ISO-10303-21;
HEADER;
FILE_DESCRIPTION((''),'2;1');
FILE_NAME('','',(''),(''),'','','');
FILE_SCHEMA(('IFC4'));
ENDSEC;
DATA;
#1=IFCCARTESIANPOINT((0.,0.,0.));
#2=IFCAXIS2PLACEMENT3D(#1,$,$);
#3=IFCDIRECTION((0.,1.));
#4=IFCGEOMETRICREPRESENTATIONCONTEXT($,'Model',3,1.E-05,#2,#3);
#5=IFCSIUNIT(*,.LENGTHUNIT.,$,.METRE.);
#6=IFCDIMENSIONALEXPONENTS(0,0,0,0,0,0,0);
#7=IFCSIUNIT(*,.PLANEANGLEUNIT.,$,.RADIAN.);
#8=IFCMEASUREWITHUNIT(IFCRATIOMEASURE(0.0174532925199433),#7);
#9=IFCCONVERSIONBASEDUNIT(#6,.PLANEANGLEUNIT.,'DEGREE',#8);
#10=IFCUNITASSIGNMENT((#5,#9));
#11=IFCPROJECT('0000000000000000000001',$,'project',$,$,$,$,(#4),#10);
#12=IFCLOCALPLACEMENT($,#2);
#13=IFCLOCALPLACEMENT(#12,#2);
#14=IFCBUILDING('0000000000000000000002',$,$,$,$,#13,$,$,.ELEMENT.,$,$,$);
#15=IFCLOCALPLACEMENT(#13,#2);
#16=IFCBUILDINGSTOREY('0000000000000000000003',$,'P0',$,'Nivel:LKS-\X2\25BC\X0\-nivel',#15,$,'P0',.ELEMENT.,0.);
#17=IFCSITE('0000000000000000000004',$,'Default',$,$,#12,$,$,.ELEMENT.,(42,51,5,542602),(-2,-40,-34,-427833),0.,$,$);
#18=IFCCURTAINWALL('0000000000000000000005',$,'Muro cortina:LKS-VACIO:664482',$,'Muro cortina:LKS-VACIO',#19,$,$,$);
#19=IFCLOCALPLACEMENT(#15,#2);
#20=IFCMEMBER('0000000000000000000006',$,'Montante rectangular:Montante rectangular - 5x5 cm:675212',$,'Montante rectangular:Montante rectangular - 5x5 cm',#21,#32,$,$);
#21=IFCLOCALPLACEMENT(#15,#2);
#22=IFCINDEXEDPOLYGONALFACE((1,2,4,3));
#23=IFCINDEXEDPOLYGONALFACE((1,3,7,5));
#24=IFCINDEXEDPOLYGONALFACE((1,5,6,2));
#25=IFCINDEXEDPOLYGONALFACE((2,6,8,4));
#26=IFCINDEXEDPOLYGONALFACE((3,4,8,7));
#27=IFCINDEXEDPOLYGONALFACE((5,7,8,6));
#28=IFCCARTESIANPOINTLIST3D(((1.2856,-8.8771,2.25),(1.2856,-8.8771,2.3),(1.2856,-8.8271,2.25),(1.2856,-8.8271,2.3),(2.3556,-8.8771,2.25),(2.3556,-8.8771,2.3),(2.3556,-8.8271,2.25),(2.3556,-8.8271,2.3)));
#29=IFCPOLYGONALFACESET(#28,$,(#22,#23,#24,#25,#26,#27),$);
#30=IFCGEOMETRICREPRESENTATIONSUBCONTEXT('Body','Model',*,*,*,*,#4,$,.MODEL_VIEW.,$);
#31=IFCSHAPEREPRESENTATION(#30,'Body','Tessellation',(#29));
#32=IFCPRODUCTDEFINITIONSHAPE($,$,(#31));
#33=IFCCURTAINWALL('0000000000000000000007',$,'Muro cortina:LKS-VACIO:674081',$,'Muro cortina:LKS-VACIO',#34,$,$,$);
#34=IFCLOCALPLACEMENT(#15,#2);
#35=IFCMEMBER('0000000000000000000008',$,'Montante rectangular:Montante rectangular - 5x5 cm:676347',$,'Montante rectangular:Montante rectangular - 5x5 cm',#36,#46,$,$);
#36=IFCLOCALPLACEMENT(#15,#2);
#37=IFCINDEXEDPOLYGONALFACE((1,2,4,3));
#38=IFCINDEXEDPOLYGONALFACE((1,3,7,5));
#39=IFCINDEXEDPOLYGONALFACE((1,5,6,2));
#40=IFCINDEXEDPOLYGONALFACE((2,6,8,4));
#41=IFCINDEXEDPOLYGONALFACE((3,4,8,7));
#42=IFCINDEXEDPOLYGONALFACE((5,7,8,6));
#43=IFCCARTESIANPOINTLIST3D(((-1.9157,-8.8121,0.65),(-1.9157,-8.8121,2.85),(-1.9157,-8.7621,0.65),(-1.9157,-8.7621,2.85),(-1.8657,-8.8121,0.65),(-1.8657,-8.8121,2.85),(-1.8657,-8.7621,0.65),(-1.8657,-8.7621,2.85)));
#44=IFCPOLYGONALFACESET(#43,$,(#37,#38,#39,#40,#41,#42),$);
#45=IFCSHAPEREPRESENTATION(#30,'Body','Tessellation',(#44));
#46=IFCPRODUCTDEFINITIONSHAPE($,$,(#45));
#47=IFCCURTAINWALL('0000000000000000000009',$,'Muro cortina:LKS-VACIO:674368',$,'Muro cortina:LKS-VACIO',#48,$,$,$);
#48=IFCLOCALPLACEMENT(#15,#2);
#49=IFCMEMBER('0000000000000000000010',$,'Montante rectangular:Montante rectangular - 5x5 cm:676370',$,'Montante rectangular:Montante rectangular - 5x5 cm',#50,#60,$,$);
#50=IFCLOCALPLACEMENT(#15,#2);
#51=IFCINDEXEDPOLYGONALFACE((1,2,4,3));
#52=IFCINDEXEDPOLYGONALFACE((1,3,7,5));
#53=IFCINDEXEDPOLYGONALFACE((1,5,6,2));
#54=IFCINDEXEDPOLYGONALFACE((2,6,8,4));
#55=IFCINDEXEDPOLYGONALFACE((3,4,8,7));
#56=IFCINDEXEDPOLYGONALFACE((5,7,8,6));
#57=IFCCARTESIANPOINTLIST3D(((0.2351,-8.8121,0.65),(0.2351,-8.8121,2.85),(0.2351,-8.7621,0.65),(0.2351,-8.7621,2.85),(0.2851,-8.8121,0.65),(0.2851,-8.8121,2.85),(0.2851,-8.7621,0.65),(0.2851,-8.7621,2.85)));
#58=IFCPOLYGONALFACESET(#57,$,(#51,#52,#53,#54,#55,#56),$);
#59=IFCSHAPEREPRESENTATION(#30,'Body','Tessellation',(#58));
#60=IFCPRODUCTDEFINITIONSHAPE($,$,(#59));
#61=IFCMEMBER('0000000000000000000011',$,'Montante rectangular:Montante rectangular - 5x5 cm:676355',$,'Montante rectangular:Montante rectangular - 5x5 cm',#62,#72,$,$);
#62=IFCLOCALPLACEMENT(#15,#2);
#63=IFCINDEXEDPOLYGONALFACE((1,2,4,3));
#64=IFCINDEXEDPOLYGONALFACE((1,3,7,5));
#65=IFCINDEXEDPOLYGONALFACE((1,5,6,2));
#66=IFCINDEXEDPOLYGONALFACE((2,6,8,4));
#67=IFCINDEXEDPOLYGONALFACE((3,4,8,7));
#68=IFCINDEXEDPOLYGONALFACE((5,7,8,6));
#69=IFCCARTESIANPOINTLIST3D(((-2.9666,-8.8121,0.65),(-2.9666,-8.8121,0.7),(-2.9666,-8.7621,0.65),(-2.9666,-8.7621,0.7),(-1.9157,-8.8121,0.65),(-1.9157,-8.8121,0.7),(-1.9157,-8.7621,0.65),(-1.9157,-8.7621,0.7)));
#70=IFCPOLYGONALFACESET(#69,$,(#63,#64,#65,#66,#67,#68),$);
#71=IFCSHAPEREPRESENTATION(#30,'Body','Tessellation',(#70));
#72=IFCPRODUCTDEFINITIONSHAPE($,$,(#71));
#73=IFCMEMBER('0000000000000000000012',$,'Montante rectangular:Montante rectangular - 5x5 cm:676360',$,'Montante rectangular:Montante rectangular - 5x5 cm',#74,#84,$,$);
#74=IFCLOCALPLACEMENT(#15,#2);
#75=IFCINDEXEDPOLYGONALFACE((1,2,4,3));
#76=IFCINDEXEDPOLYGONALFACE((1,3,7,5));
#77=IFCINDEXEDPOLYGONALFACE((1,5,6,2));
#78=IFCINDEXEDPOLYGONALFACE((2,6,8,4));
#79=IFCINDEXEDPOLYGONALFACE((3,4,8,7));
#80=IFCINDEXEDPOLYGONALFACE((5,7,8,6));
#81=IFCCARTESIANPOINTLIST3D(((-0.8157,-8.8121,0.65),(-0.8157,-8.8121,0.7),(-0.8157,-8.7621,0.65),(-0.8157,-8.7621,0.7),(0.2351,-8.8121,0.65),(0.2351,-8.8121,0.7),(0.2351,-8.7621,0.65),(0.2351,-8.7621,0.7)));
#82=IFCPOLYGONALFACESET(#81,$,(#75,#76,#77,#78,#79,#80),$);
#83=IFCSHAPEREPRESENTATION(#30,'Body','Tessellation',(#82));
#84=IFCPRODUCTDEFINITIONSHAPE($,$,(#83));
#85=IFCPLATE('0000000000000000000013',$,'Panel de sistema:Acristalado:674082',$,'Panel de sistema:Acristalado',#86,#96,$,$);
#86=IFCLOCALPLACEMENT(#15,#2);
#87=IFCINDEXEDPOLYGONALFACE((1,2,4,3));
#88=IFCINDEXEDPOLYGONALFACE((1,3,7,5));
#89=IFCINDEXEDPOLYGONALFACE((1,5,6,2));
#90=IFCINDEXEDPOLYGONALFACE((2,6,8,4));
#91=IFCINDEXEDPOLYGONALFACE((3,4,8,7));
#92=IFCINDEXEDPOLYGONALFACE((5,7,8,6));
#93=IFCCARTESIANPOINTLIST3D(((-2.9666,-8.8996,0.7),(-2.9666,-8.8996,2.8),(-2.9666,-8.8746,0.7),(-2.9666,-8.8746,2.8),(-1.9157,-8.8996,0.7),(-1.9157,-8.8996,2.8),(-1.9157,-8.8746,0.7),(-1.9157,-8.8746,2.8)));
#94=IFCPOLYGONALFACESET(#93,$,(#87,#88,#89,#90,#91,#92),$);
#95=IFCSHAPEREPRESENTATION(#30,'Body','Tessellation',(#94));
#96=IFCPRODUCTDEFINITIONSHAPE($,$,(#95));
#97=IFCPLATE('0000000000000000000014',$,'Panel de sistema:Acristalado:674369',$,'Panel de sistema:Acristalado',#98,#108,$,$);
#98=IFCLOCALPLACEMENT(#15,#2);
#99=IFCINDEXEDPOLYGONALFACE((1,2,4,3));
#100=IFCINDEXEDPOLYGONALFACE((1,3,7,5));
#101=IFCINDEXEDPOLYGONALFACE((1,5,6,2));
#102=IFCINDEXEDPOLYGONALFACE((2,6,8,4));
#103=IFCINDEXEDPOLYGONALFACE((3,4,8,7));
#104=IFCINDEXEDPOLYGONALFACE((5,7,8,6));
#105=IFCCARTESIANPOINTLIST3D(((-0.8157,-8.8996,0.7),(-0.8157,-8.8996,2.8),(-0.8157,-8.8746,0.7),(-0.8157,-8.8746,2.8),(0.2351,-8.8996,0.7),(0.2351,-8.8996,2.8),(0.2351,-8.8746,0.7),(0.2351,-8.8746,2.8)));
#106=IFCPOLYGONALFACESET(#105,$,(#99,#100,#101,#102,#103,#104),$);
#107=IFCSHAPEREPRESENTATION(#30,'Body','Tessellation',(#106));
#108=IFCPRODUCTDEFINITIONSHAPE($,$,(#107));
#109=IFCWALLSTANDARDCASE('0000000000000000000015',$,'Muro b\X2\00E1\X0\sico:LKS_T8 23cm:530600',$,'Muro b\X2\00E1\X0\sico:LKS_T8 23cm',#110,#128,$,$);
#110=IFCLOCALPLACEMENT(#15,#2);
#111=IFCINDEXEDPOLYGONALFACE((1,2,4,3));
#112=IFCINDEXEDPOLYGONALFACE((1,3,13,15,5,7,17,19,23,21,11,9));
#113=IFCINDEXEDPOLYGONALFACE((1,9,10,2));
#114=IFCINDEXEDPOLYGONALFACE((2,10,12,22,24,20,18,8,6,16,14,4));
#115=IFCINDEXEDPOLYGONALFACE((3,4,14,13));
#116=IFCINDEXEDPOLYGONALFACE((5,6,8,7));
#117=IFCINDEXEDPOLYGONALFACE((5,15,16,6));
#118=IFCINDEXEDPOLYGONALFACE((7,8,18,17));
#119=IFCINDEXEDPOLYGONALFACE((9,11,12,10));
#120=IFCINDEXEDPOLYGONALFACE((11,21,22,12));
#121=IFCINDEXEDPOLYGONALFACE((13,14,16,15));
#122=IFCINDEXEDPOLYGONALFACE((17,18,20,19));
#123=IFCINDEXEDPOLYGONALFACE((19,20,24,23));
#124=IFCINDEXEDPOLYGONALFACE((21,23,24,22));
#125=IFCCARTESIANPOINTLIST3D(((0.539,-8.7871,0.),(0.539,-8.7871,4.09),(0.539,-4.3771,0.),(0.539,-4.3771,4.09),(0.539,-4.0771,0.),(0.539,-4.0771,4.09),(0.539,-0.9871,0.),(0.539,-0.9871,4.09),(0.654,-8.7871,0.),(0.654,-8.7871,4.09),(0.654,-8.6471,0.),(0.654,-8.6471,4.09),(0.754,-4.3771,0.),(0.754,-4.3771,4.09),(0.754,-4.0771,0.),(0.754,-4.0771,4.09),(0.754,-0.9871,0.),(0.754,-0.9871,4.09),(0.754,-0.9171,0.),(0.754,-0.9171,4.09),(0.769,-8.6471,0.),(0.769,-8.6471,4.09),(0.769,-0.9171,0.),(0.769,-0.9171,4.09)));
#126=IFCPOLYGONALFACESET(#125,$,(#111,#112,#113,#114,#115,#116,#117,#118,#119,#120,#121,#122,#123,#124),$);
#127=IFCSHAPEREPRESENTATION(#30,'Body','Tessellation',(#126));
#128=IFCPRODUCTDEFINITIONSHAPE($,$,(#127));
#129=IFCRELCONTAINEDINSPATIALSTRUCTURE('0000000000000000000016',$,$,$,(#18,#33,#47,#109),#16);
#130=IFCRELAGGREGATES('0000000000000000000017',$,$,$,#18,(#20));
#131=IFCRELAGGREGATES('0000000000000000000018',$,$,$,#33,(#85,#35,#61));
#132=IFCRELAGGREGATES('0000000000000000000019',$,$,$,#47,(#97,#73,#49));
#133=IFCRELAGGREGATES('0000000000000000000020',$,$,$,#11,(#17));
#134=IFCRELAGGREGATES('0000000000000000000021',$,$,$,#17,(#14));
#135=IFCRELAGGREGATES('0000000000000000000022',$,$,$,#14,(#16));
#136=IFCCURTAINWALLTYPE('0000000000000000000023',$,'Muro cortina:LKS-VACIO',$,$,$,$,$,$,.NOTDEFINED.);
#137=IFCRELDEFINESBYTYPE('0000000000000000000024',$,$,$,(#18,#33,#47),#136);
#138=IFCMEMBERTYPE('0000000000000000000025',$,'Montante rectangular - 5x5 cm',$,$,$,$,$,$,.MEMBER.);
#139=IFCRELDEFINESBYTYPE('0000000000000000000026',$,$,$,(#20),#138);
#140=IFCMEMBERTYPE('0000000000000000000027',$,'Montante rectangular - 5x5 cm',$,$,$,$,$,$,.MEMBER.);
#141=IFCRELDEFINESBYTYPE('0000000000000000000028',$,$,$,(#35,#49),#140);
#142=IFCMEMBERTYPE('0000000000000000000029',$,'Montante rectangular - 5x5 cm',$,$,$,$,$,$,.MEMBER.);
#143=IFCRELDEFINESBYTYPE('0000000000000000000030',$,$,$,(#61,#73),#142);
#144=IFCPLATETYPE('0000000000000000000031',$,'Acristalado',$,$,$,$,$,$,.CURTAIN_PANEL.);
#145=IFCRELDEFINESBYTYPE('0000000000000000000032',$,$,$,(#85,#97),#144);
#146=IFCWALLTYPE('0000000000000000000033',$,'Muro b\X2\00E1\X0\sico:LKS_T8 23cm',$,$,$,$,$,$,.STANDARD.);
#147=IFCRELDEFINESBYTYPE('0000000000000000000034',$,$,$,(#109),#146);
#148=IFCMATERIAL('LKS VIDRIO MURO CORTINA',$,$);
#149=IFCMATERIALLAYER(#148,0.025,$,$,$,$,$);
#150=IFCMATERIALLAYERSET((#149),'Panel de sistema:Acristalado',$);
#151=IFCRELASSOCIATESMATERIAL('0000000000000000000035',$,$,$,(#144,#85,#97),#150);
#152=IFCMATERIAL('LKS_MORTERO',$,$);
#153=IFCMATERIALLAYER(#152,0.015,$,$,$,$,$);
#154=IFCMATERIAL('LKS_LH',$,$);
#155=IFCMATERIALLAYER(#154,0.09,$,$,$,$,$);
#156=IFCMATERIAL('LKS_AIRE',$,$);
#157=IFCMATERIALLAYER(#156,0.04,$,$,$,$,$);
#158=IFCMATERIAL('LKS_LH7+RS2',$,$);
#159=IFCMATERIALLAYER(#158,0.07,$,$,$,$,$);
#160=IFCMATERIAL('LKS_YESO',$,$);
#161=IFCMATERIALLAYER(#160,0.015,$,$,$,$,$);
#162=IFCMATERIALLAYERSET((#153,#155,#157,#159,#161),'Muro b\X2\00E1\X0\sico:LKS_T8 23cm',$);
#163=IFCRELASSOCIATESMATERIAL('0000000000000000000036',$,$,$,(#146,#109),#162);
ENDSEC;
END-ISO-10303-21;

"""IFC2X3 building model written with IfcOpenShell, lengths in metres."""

from ifc_helpers import new_model, entity, si_unit, converted_unit, direction, frame, frame_2d, origin, origin_2d_with_axis, place, context, subcontext, project, spatial, polyline, rectangle, extrude, clip, bounded_halfspace, source, transform, mapped, material, layer, layer_set, layer_usage, type_object, type_shapes, element, aggregate, save


model = new_model("IFC2X3")

# Units and contexts
model_context = context("Model", 3, precision=1e-05, world=origin(), true_north=direction((0.0, 1.0)))
body_context = subcontext(model_context, "Body", "Model", "MODEL_VIEW")
ifc_project = project(units=[si_unit("LENGTHUNIT", "METRE"), converted_unit("PLANEANGLEUNIT", "DEGREE", entity("IfcRatioMeasure", 0.0174532925199433), si_unit("PLANEANGLEUNIT", "RADIAN"), dimensions=[0, 0, 0, 0, 0, 0, 0])], contexts=[model_context])

# Site, building, storey
site_placement = place(None, origin())
site = spatial("IfcSite", under=ifc_project, at=site_placement, Name="Default", CompositionType="ELEMENT", RefLatitude=(42, 51, 5, 542602), RefLongitude=(-2, -40, -34, -427833), RefElevation=0.0)
building_placement = place(site_placement, origin())
building = spatial("IfcBuilding", under=site, at=building_placement, CompositionType="ELEMENT")
storey_placement = place(building_placement, origin())
storey = spatial("IfcBuildingStorey", under=building, at=storey_placement, Name="P0", ObjectType="Nivel:LKS-▼-nivel", LongName="P0", CompositionType="ELEMENT", Elevation=0.0)

# Curtain walls, members
curtain_wall_type = type_object("IfcCurtainWallType", Name="Muro cortina:LKS-VACIO", PredefinedType="NOTDEFINED")
curtain_wall_1_placement = place(storey_placement, origin())
curtain_wall_1 = element("IfcCurtainWall", 1, at=curtain_wall_1_placement, inside=storey, type_object=curtain_wall_type, Name="Muro cortina:LKS-VACIO:664482", ObjectType="Muro cortina:LKS-VACIO")
member_type_1 = type_object("IfcMemberType", Name="Montante rectangular - 5x5 cm", PredefinedType="MEMBER")
shared_shape_1 = source(origin(), body_context, "Body", "SweptSolid", [
    extrude(rectangle(XDim=0.05, YDim=0.05, at=origin_2d_with_axis()), frame((-0.025, -0.1, -1.07), z_axis=(0.0, 0.0, 1.0), x_axis=(0.0, -1.0, 0.0)), (0.0, 0.0, 1.0), 1.07),
])
type_shapes(member_type_1, [shared_shape_1])
member_1_placement = place(storey_placement, frame((1.2856, -8.9521, 2.25), z_axis=(-1.0, 0.0, 0.0), x_axis=(0.0, 0.0, -1.0)))
member_1 = element("IfcMember", 2, at=member_1_placement, type_object=member_type_1, Name="Montante rectangular:Montante rectangular - 5x5 cm:675212", ObjectType="Montante rectangular:Montante rectangular - 5x5 cm", context=body_context, shape_type="MappedRepresentation", body=[
    mapped(shared_shape_1, transform((0.0, 0.0, 0.0), scale=1.0)),
])
aggregate(curtain_wall_1, [member_1])
curtain_wall_2_placement = place(storey_placement, origin())
curtain_wall_2 = element("IfcCurtainWall", 3, at=curtain_wall_2_placement, inside=storey, type_object=curtain_wall_type, Name="Muro cortina:LKS-VACIO:674081", ObjectType="Muro cortina:LKS-VACIO")
member_type_2 = type_object("IfcMemberType", Name="Montante rectangular - 5x5 cm", PredefinedType="MEMBER")
shared_shape_2 = source(origin(), body_context, "Body", "SweptSolid", [
    extrude(rectangle(XDim=0.05, YDim=0.05, at=origin_2d_with_axis()), frame((-0.025, -0.1, -2.2), z_axis=(0.0, 0.0, 1.0), x_axis=(0.0, -1.0, 0.0)), (0.0, 0.0, 1.0), 2.2),
])
type_shapes(member_type_2, [shared_shape_2])
member_2_placement = place(storey_placement, frame((-1.8657, -8.8871, 0.65), z_axis=(0.0, 0.0, -1.0), x_axis=(1.0, 0.0, 0.0)))
member_2 = element("IfcMember", 4, at=member_2_placement, type_object=member_type_2, Name="Montante rectangular:Montante rectangular - 5x5 cm:676347", ObjectType="Montante rectangular:Montante rectangular - 5x5 cm", context=body_context, shape_type="MappedRepresentation", body=[
    mapped(shared_shape_2, transform((0.0, 0.0, 0.0), scale=1.0)),
])
curtain_wall_3_placement = place(storey_placement, origin())
curtain_wall_3 = element("IfcCurtainWall", 5, at=curtain_wall_3_placement, inside=storey, type_object=curtain_wall_type, Name="Muro cortina:LKS-VACIO:674368", ObjectType="Muro cortina:LKS-VACIO")
member_3_placement = place(storey_placement, frame((0.2851, -8.8871, 0.65), z_axis=(0.0, 0.0, -1.0), x_axis=(1.0, 0.0, 0.0)))
member_3 = element("IfcMember", 6, at=member_3_placement, type_object=member_type_2, Name="Montante rectangular:Montante rectangular - 5x5 cm:676370", ObjectType="Montante rectangular:Montante rectangular - 5x5 cm", context=body_context, shape_type="MappedRepresentation", body=[
    mapped(shared_shape_2, transform((0.0, 0.0, 0.0), scale=1.0)),
])

# Members
member_type_3 = type_object("IfcMemberType", Name="Montante rectangular - 5x5 cm", PredefinedType="MEMBER")
shared_shape_3 = source(origin(), body_context, "Body", "SweptSolid", [
    extrude(rectangle(XDim=0.05, YDim=0.05, at=origin_2d_with_axis()), frame((-0.025, -0.1, -1.0509), z_axis=(0.0, 0.0, 1.0), x_axis=(0.0, -1.0, 0.0)), (0.0, 0.0, 1.0), 1.0509),
])
type_shapes(member_type_3, [shared_shape_3])
member_4_placement = place(storey_placement, frame((-2.9666, -8.8871, 0.65), z_axis=(-1.0, 0.0, 0.0), x_axis=(0.0, 0.0, -1.0)))
member_4 = element("IfcMember", 7, at=member_4_placement, type_object=member_type_3, Name="Montante rectangular:Montante rectangular - 5x5 cm:676355", ObjectType="Montante rectangular:Montante rectangular - 5x5 cm", context=body_context, shape_type="MappedRepresentation", body=[
    mapped(shared_shape_3, transform((0.0, 0.0, 0.0), scale=1.0)),
])
member_5_placement = place(storey_placement, frame((-0.8157, -8.8871, 0.65), z_axis=(-1.0, 0.0, 0.0), x_axis=(0.0, 0.0, -1.0)))
member_5 = element("IfcMember", 8, at=member_5_placement, type_object=member_type_3, Name="Montante rectangular:Montante rectangular - 5x5 cm:676360", ObjectType="Montante rectangular:Montante rectangular - 5x5 cm", context=body_context, shape_type="MappedRepresentation", body=[
    mapped(shared_shape_3, transform((0.0, 0.0, 0.0), scale=1.0)),
])

# Plates
ifc_material_1 = material(Name="LKS VIDRIO MURO CORTINA")
ifc_layer_1 = layer(ifc_material_1, 0.025)
ifc_layer_set_1 = layer_set([ifc_layer_1], Name="Panel de sistema:Acristalado")
ifc_layer_usage_1 = layer_usage(ifc_layer_set_1, "AXIS3", "POSITIVE", 0.0)
plate_type = type_object("IfcPlateType", Name="Acristalado", PredefinedType="CURTAIN_PANEL", material=ifc_layer_set_1)
shared_shape_4 = source(origin(), body_context, "Body", "SweptSolid", [
    extrude(rectangle(XDim=0.025, YDim=1.0509, at=origin_2d_with_axis()), frame((0.0, 0.0, 0.0), z_axis=(0.0, 0.0, 1.0), x_axis=(0.0, 1.0, 0.0)), (0.0, 0.0, 1.0), 2.1),
])
type_shapes(plate_type, [shared_shape_4])
plate_1_placement = place(curtain_wall_2_placement, frame((-2.4412, -8.8871, 0.7)))
plate_1 = element("IfcPlate", 9, at=plate_1_placement, type_object=plate_type, material=ifc_layer_usage_1, Name="Panel de sistema:Acristalado:674082", ObjectType="Panel de sistema:Acristalado", context=body_context, shape_type="MappedRepresentation", body=[
    mapped(shared_shape_4, transform((0.0, 0.0, 0.0), scale=1.0)),
])
aggregate(curtain_wall_2, [plate_1, member_2, member_4])
ifc_layer_usage_2 = layer_usage(ifc_layer_set_1, "AXIS3", "POSITIVE", 0.0)
plate_2_placement = place(curtain_wall_3_placement, frame((-0.2903, -8.8871, 0.7)))
plate_2 = element("IfcPlate", 10, at=plate_2_placement, type_object=plate_type, material=ifc_layer_usage_2, Name="Panel de sistema:Acristalado:674369", ObjectType="Panel de sistema:Acristalado", context=body_context, shape_type="MappedRepresentation", body=[
    mapped(shared_shape_4, transform((0.0, 0.0, 0.0), scale=1.0)),
])
aggregate(curtain_wall_3, [plate_2, member_5, member_3])

# Wall, opening
ifc_material_2 = material(Name="LKS_MORTERO")
ifc_layer_2 = layer(ifc_material_2, 0.015)
ifc_material_3 = material(Name="LKS_LH")
ifc_layer_3 = layer(ifc_material_3, 0.09)
ifc_material_4 = material(Name="LKS_AIRE")
ifc_layer_4 = layer(ifc_material_4, 0.04)
ifc_material_5 = material(Name="LKS_LH7+RS2")
ifc_layer_5 = layer(ifc_material_5, 0.07)
ifc_material_6 = material(Name="LKS_YESO")
ifc_layer_6 = layer(ifc_material_6, 0.015)
ifc_layer_set_2 = layer_set([ifc_layer_2, ifc_layer_3, ifc_layer_4, ifc_layer_5, ifc_layer_6], Name="Muro básico:LKS_T8 23cm")
ifc_layer_usage_3 = layer_usage(ifc_layer_set_2, "AXIS2", "POSITIVE", -0.115)
wall_type_1 = type_object("IfcWallType", Name="Muro básico:LKS_T8 23cm", PredefinedType="STANDARD", material=ifc_layer_set_2)
wall_1_placement = place(storey_placement, frame((0.654, -8.7871, 0.0), z_axis=(0.0, 0.0, 1.0), x_axis=(0.0, 1.0, 0.0)))
wall_1 = element("IfcWallStandardCase", 11, at=wall_1_placement, inside=storey, type_object=wall_type_1, material=ifc_layer_usage_3, Name="Muro básico:LKS_T8 23cm:530600", ObjectType="Muro básico:LKS_T8 23cm", context=body_context, shape_type="Clipping", body=[
    clip(clip(clip(clip(extrude(rectangle(XDim=7.87, YDim=0.23, at=frame_2d((3.935, 0.0), x_axis=(-1.0, 0.0))), origin(), (0.0, 0.0, 1.0), 4.09), bounded_halfspace(frame((0.14, 0.0, 0.0), z_axis=(0.0, 1.0, 0.0), x_axis=(0.0, 0.0, -1.0)), True, frame((0.14, 0.0, 0.0), z_axis=(0.0, 1.0, 0.0), x_axis=(0.0, 0.0, -1.0)), polyline([(0.0, 0.0), (0.0, 0.14), (-4.09, 0.14), (-4.09, 0.0), (-3.958, 0.0), (0.0, 0.0)]))), bounded_halfspace(frame((0.14, 0.0, 4.09), z_axis=(1.0, 0.0, 0.0), x_axis=(0.0, 0.0, -1.0)), True, frame((0.14, 0.0, 4.09), z_axis=(1.0, 0.0, 0.0), x_axis=(0.0, 0.0, -1.0)), polyline([(0.0, 0.0), (0.0, -0.115), (4.09, -0.115), (4.09, 0.0), (0.132, 0.0), (0.0, 0.0)]))), bounded_halfspace(frame((7.8, -0.1, 0.0), z_axis=(0.0, -1.0, 0.0), x_axis=(0.0, 0.0, -1.0)), True, frame((7.8, -0.1, 0.0), z_axis=(0.0, -1.0, 0.0), x_axis=(0.0, 0.0, -1.0)), polyline([(0.0, 0.0), (0.0, 0.07), (-3.9, 0.07), (-3.9, 0.0689), (-4.09, 0.0689), (-4.09, 0.0), (0.0, 0.0)]))), bounded_halfspace(frame((7.8, -0.1, 4.09), z_axis=(-1.0, 0.0, 0.0), x_axis=(0.0, 0.0, -1.0)), True, frame((7.8, -0.1, 4.09), z_axis=(-1.0, 0.0, 0.0), x_axis=(0.0, 0.0, -1.0)), polyline([(0.0, 0.0), (0.0, -0.215), (4.09, -0.215), (4.09, 0.0), (0.0, 0.0)]))),
])
opening_1_placement = place(storey_placement, frame((0.654, -8.7871, 0.0), z_axis=(0.0, 0.0, 1.0), x_axis=(0.0, 1.0, 0.0)))
element("IfcOpeningElement", 12, at=opening_1_placement, cuts=wall_1, ObjectType="Opening", context=body_context, shape_type="SweptSolid", body=[
    extrude(rectangle(XDim=4.09, YDim=0.215, at=frame_2d((0.3826, 0.0215), x_axis=(1.0, 0.0))), frame((4.41, -0.014, 2.4276), z_axis=(1.0, 0.0, 0.0), x_axis=(0.0, 0.0, -1.0)), (0.0, 0.0, 1.0), 0.3),
])

save(model, "model.ifc")
